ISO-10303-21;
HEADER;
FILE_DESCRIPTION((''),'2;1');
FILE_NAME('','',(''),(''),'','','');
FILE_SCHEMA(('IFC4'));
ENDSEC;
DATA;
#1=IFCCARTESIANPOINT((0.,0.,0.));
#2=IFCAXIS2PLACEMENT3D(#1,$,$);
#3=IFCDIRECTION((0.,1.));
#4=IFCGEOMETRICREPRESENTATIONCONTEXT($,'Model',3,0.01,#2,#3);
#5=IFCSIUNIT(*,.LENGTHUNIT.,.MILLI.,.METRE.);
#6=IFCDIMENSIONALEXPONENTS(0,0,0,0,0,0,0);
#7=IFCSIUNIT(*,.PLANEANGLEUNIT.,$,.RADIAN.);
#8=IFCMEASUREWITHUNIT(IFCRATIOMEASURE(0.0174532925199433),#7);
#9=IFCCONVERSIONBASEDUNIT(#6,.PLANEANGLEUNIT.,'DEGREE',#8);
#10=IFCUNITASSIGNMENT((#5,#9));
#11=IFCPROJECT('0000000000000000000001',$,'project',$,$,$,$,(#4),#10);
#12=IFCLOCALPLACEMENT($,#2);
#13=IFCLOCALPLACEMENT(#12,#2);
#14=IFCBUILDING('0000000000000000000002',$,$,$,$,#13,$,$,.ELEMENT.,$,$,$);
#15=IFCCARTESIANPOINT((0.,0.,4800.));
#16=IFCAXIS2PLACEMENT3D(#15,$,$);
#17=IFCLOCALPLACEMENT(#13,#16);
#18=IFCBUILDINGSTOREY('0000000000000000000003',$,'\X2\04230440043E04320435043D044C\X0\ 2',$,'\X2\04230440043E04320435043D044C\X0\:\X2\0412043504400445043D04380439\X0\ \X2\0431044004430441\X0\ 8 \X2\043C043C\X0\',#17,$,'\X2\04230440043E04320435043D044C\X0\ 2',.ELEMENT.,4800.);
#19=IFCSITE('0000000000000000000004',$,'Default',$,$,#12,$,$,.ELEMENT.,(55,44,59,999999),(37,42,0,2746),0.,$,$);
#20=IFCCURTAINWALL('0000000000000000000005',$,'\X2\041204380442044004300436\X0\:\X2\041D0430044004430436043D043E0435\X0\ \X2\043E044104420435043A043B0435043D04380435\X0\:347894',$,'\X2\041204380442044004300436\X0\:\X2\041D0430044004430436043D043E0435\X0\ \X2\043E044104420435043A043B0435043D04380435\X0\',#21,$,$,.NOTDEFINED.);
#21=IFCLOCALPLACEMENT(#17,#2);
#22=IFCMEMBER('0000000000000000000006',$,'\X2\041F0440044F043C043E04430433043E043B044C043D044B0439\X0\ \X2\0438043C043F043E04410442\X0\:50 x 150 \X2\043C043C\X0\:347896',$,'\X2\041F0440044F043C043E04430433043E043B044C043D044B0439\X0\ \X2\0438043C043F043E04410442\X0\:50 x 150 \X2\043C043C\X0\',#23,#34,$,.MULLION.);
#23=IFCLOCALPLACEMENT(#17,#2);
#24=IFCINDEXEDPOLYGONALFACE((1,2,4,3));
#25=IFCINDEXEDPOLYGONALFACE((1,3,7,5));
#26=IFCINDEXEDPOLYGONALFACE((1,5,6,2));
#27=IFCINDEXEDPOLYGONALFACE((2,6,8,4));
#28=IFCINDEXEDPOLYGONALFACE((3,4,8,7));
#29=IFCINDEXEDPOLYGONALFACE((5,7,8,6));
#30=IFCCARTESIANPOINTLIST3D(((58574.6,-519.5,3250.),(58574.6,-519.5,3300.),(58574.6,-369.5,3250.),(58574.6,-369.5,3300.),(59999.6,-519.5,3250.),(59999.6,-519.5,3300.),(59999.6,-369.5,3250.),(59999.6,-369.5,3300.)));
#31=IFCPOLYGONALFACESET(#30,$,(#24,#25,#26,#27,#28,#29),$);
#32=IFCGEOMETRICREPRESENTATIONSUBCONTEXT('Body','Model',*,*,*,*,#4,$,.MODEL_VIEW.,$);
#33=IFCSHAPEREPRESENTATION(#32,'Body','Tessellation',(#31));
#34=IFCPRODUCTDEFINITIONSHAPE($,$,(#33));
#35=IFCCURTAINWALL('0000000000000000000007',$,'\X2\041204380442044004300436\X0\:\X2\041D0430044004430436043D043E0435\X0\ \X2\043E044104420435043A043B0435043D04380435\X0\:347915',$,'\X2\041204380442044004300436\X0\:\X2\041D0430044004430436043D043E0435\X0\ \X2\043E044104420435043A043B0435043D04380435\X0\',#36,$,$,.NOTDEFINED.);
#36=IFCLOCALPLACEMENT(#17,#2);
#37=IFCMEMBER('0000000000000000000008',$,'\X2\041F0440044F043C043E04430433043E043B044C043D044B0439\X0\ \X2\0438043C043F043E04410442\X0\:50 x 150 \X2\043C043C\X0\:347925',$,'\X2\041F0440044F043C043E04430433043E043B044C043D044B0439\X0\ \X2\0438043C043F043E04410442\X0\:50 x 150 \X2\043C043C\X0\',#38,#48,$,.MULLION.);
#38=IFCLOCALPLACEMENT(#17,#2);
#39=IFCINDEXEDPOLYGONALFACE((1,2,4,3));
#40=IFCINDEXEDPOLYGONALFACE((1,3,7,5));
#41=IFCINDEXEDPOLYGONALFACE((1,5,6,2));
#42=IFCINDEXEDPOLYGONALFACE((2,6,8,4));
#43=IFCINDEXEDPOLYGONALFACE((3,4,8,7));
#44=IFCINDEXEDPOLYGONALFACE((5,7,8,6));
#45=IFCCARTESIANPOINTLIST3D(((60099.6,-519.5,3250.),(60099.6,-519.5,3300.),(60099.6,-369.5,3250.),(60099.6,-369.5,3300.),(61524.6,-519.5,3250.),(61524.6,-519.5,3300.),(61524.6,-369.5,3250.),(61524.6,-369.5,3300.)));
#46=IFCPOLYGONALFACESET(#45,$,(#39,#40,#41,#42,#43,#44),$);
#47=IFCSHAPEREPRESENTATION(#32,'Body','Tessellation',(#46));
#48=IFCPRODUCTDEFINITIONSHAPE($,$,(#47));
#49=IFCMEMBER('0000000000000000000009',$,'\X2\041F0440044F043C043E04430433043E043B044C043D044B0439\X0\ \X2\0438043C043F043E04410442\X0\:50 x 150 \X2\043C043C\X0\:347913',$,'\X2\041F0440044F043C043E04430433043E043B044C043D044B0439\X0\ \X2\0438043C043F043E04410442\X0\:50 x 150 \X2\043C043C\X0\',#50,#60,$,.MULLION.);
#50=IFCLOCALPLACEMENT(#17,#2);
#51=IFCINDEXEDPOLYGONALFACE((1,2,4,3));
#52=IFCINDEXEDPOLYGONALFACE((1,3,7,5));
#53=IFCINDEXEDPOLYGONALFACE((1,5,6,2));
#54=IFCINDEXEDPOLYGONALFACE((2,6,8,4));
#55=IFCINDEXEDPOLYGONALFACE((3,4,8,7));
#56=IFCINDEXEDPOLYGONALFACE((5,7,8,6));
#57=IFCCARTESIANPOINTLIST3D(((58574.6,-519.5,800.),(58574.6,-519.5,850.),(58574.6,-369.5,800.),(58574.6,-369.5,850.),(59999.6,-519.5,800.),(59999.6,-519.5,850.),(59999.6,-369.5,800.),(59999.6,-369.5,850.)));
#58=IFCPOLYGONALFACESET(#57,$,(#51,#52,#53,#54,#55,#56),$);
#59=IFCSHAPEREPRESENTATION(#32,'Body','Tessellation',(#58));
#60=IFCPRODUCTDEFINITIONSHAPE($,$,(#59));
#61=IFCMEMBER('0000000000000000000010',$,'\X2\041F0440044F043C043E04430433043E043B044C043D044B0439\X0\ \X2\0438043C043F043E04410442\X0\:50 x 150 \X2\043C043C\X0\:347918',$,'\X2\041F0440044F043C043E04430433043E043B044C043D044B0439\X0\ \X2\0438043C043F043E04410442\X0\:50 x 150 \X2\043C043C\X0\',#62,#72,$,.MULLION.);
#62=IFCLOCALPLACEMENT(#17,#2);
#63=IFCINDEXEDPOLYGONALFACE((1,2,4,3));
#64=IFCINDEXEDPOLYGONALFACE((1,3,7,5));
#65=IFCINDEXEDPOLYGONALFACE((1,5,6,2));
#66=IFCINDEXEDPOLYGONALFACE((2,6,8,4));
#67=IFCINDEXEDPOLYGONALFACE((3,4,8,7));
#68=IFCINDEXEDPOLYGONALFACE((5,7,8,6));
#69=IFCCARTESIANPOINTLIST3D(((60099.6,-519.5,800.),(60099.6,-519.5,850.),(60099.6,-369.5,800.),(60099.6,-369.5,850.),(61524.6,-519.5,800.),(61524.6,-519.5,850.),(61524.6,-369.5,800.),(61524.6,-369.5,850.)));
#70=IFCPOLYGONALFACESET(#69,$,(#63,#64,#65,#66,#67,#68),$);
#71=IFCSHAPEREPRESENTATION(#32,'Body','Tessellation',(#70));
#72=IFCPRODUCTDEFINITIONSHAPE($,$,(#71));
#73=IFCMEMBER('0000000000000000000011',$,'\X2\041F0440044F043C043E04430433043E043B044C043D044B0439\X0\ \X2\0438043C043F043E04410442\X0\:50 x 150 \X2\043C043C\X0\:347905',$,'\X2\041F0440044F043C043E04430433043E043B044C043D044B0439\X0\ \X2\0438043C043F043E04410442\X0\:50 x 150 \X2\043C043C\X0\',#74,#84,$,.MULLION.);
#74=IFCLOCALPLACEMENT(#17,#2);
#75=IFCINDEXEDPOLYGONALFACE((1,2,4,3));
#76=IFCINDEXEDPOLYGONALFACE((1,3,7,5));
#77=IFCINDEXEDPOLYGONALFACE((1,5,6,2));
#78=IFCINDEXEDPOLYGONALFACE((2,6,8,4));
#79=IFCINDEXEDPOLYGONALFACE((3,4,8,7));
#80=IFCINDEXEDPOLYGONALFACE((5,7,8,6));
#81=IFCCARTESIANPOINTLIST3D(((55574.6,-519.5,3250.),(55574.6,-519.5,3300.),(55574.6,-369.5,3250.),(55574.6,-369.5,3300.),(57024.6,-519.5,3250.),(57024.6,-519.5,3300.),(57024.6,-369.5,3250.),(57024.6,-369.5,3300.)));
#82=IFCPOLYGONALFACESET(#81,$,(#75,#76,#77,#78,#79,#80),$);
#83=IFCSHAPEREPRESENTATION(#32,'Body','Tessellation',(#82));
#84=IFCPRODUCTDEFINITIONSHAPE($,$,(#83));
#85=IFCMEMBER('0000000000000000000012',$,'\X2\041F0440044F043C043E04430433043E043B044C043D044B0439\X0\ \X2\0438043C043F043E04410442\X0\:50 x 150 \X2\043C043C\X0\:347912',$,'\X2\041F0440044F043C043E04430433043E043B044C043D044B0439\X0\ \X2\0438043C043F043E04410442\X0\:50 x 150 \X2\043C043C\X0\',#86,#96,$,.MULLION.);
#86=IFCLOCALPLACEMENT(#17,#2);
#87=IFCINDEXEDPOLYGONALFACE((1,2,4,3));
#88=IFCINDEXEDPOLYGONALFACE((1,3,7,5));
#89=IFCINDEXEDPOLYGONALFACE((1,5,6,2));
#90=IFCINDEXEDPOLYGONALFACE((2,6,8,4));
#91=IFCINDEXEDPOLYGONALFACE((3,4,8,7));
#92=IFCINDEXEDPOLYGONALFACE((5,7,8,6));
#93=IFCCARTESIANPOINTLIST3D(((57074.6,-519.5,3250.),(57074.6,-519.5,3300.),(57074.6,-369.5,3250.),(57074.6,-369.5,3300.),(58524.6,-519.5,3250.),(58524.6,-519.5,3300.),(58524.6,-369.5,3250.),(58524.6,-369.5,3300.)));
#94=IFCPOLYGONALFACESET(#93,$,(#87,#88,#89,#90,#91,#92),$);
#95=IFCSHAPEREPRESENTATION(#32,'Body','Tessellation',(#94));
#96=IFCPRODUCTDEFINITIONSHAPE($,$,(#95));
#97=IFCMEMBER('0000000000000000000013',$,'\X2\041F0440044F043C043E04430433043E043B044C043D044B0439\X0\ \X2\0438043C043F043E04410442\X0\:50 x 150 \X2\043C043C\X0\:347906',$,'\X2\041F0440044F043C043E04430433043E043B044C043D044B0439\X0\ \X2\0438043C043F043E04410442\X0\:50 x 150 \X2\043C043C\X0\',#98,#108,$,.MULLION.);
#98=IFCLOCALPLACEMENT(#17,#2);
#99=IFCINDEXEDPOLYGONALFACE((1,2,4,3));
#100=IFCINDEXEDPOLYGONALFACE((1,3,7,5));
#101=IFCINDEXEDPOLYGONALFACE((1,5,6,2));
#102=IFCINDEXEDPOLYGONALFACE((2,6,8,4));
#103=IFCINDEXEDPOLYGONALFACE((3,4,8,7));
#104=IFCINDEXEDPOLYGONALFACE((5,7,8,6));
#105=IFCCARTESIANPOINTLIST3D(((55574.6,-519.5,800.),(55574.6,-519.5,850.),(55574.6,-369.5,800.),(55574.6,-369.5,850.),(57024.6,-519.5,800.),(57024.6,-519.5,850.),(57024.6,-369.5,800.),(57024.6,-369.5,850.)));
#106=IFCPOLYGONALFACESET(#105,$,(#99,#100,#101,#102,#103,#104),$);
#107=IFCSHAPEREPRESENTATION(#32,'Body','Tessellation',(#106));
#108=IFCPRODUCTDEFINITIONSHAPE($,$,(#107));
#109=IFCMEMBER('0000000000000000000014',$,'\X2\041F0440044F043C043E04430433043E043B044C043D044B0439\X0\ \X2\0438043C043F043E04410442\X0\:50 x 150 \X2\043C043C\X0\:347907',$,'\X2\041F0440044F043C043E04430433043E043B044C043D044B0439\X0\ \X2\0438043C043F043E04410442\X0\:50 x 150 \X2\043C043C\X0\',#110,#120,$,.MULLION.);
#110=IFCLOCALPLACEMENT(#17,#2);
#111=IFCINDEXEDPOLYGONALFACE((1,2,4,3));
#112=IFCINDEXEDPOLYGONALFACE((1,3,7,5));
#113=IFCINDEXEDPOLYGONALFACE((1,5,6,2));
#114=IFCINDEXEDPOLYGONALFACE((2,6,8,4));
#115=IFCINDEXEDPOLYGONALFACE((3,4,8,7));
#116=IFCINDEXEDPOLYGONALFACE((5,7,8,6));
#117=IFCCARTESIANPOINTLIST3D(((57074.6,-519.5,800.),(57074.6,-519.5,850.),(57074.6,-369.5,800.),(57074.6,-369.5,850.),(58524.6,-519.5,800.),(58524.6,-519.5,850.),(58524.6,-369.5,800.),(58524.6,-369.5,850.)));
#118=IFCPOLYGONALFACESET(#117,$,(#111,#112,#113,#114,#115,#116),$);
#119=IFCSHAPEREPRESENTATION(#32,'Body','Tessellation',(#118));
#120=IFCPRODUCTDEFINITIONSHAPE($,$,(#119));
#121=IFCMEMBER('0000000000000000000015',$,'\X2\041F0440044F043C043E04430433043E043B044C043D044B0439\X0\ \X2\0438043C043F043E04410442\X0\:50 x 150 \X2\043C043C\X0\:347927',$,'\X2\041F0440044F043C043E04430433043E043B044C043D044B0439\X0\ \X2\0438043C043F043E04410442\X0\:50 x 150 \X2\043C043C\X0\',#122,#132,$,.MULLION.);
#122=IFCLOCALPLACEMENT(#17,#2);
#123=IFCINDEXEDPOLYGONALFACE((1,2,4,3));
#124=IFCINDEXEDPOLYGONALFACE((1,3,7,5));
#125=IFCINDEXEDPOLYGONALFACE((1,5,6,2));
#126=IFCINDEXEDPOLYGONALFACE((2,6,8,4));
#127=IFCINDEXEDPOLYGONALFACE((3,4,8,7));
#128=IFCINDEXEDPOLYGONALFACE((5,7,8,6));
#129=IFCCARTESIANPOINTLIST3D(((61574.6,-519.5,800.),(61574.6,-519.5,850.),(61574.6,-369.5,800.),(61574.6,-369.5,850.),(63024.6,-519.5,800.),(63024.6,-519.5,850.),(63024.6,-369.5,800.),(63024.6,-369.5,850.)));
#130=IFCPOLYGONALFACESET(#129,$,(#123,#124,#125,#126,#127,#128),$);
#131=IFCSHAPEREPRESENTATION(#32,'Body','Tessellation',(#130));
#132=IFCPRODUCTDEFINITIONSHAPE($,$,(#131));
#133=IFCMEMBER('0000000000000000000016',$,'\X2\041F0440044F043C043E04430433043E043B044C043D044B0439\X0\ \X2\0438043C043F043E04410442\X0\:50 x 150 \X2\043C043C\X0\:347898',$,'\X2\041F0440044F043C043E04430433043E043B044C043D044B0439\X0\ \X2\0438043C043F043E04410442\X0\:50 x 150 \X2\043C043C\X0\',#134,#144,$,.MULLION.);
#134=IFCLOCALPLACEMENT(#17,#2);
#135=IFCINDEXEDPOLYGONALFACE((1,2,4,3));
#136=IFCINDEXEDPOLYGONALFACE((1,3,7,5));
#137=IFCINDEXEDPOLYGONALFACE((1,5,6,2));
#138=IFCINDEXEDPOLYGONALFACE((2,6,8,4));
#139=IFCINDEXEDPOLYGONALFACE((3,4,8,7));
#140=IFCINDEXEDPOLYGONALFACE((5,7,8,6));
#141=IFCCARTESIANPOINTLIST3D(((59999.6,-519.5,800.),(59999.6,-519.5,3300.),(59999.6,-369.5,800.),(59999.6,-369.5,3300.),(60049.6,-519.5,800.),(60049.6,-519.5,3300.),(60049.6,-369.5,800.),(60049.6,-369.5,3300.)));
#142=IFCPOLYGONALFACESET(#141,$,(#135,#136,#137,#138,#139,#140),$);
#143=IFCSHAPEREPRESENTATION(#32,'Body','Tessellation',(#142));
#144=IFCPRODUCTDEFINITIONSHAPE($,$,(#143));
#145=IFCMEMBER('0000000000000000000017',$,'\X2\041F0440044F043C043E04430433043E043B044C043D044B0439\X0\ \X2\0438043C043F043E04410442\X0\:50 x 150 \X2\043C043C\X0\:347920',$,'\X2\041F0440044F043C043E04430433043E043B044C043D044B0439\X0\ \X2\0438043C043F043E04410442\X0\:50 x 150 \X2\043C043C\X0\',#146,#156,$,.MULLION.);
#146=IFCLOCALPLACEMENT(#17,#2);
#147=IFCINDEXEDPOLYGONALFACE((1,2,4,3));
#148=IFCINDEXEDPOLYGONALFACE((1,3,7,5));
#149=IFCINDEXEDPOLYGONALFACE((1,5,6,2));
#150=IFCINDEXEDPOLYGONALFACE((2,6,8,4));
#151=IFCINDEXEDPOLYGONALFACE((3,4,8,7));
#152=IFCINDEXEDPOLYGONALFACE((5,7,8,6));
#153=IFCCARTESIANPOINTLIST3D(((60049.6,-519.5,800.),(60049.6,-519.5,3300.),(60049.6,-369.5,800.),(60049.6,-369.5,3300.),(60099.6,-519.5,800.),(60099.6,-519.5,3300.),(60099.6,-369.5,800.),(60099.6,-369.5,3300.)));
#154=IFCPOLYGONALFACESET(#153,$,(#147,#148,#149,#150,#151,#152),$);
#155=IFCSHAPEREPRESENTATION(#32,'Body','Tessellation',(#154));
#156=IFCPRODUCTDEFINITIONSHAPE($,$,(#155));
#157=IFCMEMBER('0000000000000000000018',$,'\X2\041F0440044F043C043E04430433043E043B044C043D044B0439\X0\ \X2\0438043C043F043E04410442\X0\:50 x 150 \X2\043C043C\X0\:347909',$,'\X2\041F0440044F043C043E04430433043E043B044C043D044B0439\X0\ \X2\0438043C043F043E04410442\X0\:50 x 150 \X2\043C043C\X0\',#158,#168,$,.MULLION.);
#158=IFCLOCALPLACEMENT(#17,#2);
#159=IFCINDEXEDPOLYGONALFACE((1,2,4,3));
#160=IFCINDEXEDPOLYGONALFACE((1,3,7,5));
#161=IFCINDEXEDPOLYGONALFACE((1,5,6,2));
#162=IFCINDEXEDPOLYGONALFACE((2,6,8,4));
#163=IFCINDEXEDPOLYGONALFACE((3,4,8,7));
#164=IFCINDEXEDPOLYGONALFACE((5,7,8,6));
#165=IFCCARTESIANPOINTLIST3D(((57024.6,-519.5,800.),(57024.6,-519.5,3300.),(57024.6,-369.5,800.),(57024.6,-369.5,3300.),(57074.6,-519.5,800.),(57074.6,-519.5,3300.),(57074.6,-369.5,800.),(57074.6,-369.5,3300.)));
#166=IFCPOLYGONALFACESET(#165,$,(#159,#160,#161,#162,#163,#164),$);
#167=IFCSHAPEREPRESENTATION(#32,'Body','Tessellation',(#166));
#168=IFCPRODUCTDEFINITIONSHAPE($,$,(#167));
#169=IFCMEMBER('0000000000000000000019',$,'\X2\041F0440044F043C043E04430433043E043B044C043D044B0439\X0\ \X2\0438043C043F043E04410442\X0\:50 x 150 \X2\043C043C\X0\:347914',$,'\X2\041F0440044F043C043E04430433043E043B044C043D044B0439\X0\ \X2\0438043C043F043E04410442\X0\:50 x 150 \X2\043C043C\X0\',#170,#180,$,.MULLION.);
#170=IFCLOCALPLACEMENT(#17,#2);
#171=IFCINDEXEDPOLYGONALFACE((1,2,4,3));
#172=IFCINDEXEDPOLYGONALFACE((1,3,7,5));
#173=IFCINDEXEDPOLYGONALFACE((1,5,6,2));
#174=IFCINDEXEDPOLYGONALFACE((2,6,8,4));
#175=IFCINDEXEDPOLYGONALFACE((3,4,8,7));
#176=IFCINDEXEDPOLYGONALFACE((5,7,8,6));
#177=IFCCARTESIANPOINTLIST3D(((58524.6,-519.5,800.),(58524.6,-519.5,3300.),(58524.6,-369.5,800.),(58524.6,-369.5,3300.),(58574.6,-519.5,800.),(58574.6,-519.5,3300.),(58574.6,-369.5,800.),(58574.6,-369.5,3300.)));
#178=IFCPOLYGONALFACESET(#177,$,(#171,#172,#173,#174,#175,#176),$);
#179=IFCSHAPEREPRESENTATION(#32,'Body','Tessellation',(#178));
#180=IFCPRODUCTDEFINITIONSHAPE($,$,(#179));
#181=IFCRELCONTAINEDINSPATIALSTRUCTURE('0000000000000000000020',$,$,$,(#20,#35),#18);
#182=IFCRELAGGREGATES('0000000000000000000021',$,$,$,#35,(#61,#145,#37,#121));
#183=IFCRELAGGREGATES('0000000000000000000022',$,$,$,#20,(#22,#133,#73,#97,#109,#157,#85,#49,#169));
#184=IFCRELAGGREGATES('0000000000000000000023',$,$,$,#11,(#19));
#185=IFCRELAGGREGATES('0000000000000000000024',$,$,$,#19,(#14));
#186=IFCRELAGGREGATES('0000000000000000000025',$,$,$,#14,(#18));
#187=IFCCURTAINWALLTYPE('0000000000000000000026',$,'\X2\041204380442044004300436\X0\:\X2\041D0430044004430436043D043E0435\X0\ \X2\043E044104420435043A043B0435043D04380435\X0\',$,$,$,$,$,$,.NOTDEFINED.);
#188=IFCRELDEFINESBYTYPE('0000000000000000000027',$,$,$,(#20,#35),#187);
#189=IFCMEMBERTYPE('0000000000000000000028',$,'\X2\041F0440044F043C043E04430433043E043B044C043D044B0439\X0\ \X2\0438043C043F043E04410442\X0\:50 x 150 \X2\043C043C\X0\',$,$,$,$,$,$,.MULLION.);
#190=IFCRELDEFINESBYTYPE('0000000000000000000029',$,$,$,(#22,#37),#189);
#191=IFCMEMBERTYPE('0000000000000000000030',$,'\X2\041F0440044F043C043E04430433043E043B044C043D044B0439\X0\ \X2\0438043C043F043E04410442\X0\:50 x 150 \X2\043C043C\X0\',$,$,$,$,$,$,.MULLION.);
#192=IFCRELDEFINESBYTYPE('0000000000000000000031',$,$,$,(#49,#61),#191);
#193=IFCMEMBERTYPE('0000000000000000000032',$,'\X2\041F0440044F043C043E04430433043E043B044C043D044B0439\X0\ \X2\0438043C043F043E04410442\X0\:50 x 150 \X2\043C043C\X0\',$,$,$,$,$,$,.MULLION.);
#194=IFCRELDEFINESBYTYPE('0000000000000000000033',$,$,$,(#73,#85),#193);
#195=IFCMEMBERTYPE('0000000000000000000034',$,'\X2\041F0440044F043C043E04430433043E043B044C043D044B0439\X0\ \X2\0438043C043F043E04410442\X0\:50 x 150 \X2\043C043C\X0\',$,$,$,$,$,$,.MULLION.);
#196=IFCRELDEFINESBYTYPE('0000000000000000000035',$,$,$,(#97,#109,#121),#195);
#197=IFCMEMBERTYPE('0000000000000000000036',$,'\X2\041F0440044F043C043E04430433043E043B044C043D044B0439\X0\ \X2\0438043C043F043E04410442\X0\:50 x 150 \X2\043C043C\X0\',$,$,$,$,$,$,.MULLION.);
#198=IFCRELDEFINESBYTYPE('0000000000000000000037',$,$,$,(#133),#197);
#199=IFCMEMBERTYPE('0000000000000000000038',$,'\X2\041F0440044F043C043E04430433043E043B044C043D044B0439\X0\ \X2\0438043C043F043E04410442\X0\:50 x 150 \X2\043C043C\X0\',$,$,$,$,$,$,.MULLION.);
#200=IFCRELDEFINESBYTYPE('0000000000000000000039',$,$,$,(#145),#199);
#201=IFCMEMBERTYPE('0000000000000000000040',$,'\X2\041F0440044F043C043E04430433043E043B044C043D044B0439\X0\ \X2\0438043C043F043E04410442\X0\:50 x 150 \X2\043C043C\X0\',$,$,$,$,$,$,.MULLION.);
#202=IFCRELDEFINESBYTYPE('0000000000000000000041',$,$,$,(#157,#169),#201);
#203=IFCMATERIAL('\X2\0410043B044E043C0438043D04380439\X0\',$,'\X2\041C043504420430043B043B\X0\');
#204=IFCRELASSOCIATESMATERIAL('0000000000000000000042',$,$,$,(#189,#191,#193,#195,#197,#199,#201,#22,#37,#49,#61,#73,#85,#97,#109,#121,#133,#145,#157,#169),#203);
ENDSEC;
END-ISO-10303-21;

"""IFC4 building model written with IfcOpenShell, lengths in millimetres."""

from ifc_helpers import new_model, entity, si_unit, converted_unit, direction, frame, origin, origin_2d_with_axis, place, context, subcontext, project, spatial, rectangle, extrude, source, transform, mapped, material, material_profile, profile_set, profile_usage, type_object, type_shapes, element, aggregate, save


model = new_model("IFC4")

# Units and contexts
model_context = context("Model", 3, precision=0.01, world=origin(), true_north=direction((0.0, 1.0)))
body_context = subcontext(model_context, "Body", "Model", "MODEL_VIEW")
ifc_project = project(units=[si_unit("LENGTHUNIT", "METRE", prefix="MILLI"), converted_unit("PLANEANGLEUNIT", "DEGREE", entity("IfcRatioMeasure", 0.0174532925199433), si_unit("PLANEANGLEUNIT", "RADIAN"), dimensions=[0, 0, 0, 0, 0, 0, 0])], contexts=[model_context])

# Site, building, storey
site_placement = place(None, origin())
site = spatial("IfcSite", under=ifc_project, at=site_placement, Name="Default", CompositionType="ELEMENT", RefLatitude=(55, 44, 59, 999999), RefLongitude=(37, 42, 0, 2746), RefElevation=0.0)
building_placement = place(site_placement, origin())
building = spatial("IfcBuilding", under=site, at=building_placement, CompositionType="ELEMENT")
storey_placement = place(building_placement, frame((0.0, 0.0, 4800.0)))
storey = spatial("IfcBuildingStorey", under=building, at=storey_placement, Name="Уровень 2", ObjectType="Уровень:Верхний брус 8 мм", LongName="Уровень 2", CompositionType="ELEMENT", Elevation=4800.0)

# Curtain walls, members
curtain_wall_type = type_object("IfcCurtainWallType", Name="Витраж:Наружное остекление", PredefinedType="NOTDEFINED")
curtain_wall_1_placement = place(storey_placement, frame((0.0, 0.0, -4800.0)))
curtain_wall_1 = element("IfcCurtainWall", 1, at=curtain_wall_1_placement, inside=storey, type_object=curtain_wall_type, Name="Витраж:Наружное остекление:347894", ObjectType="Витраж:Наружное остекление", PredefinedType="NOTDEFINED")
ifc_material_1 = material(Name="Алюминий", Category="Металл")
ifc_material_profile = material_profile(ifc_material_1, rectangle(XDim=150.0, YDim=50.0, at=origin_2d_with_axis()), Name="50 x 150 мм")
ifc_profile_set = profile_set([ifc_material_profile], Name="50 x 150 мм")
ifc_profile_usage_1 = profile_usage(ifc_profile_set)
member_type_1 = type_object("IfcMemberType", Name="Прямоугольный импост:50 x 150 мм", PredefinedType="MULLION", material=ifc_profile_set)
shared_shape_1 = source(origin(), body_context, "Body", "SweptSolid", [
    extrude(rectangle(XDim=150.0, YDim=50.0, at=origin_2d_with_axis()), frame((-25.0, 0.0, -1425.0), z_axis=(0.0, 0.0, 1.0), x_axis=(0.0, -1.0, 0.0)), (0.0, 0.0, 1.0), 1425.0),
])
type_shapes(member_type_1, [shared_shape_1])
member_1_placement = place(storey_placement, frame((59999.6, -444.5, 3300.0), z_axis=(1.0, 0.0, 0.0), x_axis=(0.0, 0.0, 1.0)))
member_1 = element("IfcMember", 2, at=member_1_placement, type_object=member_type_1, material=ifc_profile_usage_1, Name="Прямоугольный импост:50 x 150 мм:347896", ObjectType="Прямоугольный импост:50 x 150 мм", PredefinedType="MULLION", context=body_context, shape_type="MappedRepresentation", body=[
    mapped(shared_shape_1, transform((0.0, 0.0, 0.0), scale=1.0)),
])
curtain_wall_2_placement = place(storey_placement, frame((0.0, 0.0, -4800.0)))
curtain_wall_2 = element("IfcCurtainWall", 3, at=curtain_wall_2_placement, inside=storey, type_object=curtain_wall_type, Name="Витраж:Наружное остекление:347915", ObjectType="Витраж:Наружное остекление", PredefinedType="NOTDEFINED")
ifc_profile_usage_2 = profile_usage(ifc_profile_set)
member_2_placement = place(storey_placement, frame((61524.6, -444.5, 3300.0), z_axis=(1.0, 0.0, 0.0), x_axis=(0.0, 0.0, 1.0)))
member_2 = element("IfcMember", 4, at=member_2_placement, type_object=member_type_1, material=ifc_profile_usage_2, Name="Прямоугольный импост:50 x 150 мм:347925", ObjectType="Прямоугольный импост:50 x 150 мм", PredefinedType="MULLION", context=body_context, shape_type="MappedRepresentation", body=[
    mapped(shared_shape_1, transform((0.0, 0.0, 0.0), scale=1.0)),
])

# Members
ifc_profile_usage_3 = profile_usage(ifc_profile_set)
member_type_2 = type_object("IfcMemberType", Name="Прямоугольный импост:50 x 150 мм", PredefinedType="MULLION", material=ifc_profile_set)
shared_shape_2 = source(origin(), body_context, "Body", "SweptSolid", [
    extrude(rectangle(XDim=150.0, YDim=50.0, at=origin_2d_with_axis()), frame((-25.0, 0.0, -1425.0), z_axis=(0.0, 0.0, 1.0), x_axis=(0.0, -1.0, 0.0)), (0.0, 0.0, 1.0), 1425.0),
])
type_shapes(member_type_2, [shared_shape_2])
member_3_placement = place(storey_placement, frame((58574.6, -444.5, 800.0), z_axis=(-1.0, 0.0, 0.0), x_axis=(0.0, 0.0, -1.0)))
member_3 = element("IfcMember", 5, at=member_3_placement, type_object=member_type_2, material=ifc_profile_usage_3, Name="Прямоугольный импост:50 x 150 мм:347913", ObjectType="Прямоугольный импост:50 x 150 мм", PredefinedType="MULLION", context=body_context, shape_type="MappedRepresentation", body=[
    mapped(shared_shape_2, transform((0.0, 0.0, 0.0), scale=1.0)),
])
ifc_profile_usage_4 = profile_usage(ifc_profile_set)
member_4_placement = place(storey_placement, frame((60099.6, -444.5, 800.0), z_axis=(-1.0, 0.0, 0.0), x_axis=(0.0, 0.0, -1.0)))
member_4 = element("IfcMember", 6, at=member_4_placement, type_object=member_type_2, material=ifc_profile_usage_4, Name="Прямоугольный импост:50 x 150 мм:347918", ObjectType="Прямоугольный импост:50 x 150 мм", PredefinedType="MULLION", context=body_context, shape_type="MappedRepresentation", body=[
    mapped(shared_shape_2, transform((0.0, 0.0, 0.0), scale=1.0)),
])
ifc_profile_usage_5 = profile_usage(ifc_profile_set)
member_type_3 = type_object("IfcMemberType", Name="Прямоугольный импост:50 x 150 мм", PredefinedType="MULLION", material=ifc_profile_set)
shared_shape_3 = source(origin(), body_context, "Body", "SweptSolid", [
    extrude(rectangle(XDim=150.0, YDim=50.0, at=origin_2d_with_axis()), frame((-25.0, 0.0, -1450.0), z_axis=(0.0, 0.0, 1.0), x_axis=(0.0, -1.0, 0.0)), (0.0, 0.0, 1.0), 1450.0),
])
type_shapes(member_type_3, [shared_shape_3])
member_5_placement = place(storey_placement, frame((57024.6, -444.5, 3300.0), z_axis=(1.0, 0.0, 0.0), x_axis=(0.0, 0.0, 1.0)))
member_5 = element("IfcMember", 7, at=member_5_placement, type_object=member_type_3, material=ifc_profile_usage_5, Name="Прямоугольный импост:50 x 150 мм:347905", ObjectType="Прямоугольный импост:50 x 150 мм", PredefinedType="MULLION", context=body_context, shape_type="MappedRepresentation", body=[
    mapped(shared_shape_3, transform((0.0, 0.0, 0.0), scale=1.0)),
])
ifc_profile_usage_6 = profile_usage(ifc_profile_set)
member_6_placement = place(storey_placement, frame((58524.6, -444.5, 3300.0), z_axis=(1.0, 0.0, 0.0), x_axis=(0.0, 0.0, 1.0)))
member_6 = element("IfcMember", 8, at=member_6_placement, type_object=member_type_3, material=ifc_profile_usage_6, Name="Прямоугольный импост:50 x 150 мм:347912", ObjectType="Прямоугольный импост:50 x 150 мм", PredefinedType="MULLION", context=body_context, shape_type="MappedRepresentation", body=[
    mapped(shared_shape_3, transform((0.0, 0.0, 0.0), scale=1.0)),
])
ifc_profile_usage_7 = profile_usage(ifc_profile_set)
member_type_4 = type_object("IfcMemberType", Name="Прямоугольный импост:50 x 150 мм", PredefinedType="MULLION", material=ifc_profile_set)
shared_shape_4 = source(origin(), body_context, "Body", "SweptSolid", [
    extrude(rectangle(XDim=150.0, YDim=50.0, at=origin_2d_with_axis()), frame((-25.0, 0.0, -1450.0), z_axis=(0.0, 0.0, 1.0), x_axis=(0.0, -1.0, 0.0)), (0.0, 0.0, 1.0), 1450.0),
])
type_shapes(member_type_4, [shared_shape_4])
member_7_placement = place(storey_placement, frame((55574.6, -444.5, 800.0), z_axis=(-1.0, 0.0, 0.0), x_axis=(0.0, 0.0, -1.0)))
member_7 = element("IfcMember", 9, at=member_7_placement, type_object=member_type_4, material=ifc_profile_usage_7, Name="Прямоугольный импост:50 x 150 мм:347906", ObjectType="Прямоугольный импост:50 x 150 мм", PredefinedType="MULLION", context=body_context, shape_type="MappedRepresentation", body=[
    mapped(shared_shape_4, transform((0.0, 0.0, 0.0), scale=1.0)),
])
ifc_profile_usage_8 = profile_usage(ifc_profile_set)
member_8_placement = place(storey_placement, frame((57074.6, -444.5, 800.0), z_axis=(-1.0, 0.0, 0.0), x_axis=(0.0, 0.0, -1.0)))
member_8 = element("IfcMember", 10, at=member_8_placement, type_object=member_type_4, material=ifc_profile_usage_8, Name="Прямоугольный импост:50 x 150 мм:347907", ObjectType="Прямоугольный импост:50 x 150 мм", PredefinedType="MULLION", context=body_context, shape_type="MappedRepresentation", body=[
    mapped(shared_shape_4, transform((0.0, 0.0, 0.0), scale=1.0)),
])
ifc_profile_usage_9 = profile_usage(ifc_profile_set)
member_9_placement = place(storey_placement, frame((61574.6, -444.5, 800.0), z_axis=(-1.0, 0.0, 0.0), x_axis=(0.0, 0.0, -1.0)))
member_9 = element("IfcMember", 11, at=member_9_placement, type_object=member_type_4, material=ifc_profile_usage_9, Name="Прямоугольный импост:50 x 150 мм:347927", ObjectType="Прямоугольный импост:50 x 150 мм", PredefinedType="MULLION", context=body_context, shape_type="MappedRepresentation", body=[
    mapped(shared_shape_4, transform((0.0, 0.0, 0.0), scale=1.0)),
])
ifc_profile_usage_10 = profile_usage(ifc_profile_set)
member_type_5 = type_object("IfcMemberType", Name="Прямоугольный импост:50 x 150 мм", PredefinedType="MULLION", material=ifc_profile_set)
shared_shape_5 = source(origin(), body_context, "Body", "SweptSolid", [
    extrude(rectangle(XDim=150.0, YDim=50.0, at=origin_2d_with_axis()), frame((-25.0, 0.0, -2500.0), z_axis=(0.0, 0.0, 1.0), x_axis=(0.0, -1.0, 0.0)), (0.0, 0.0, 1.0), 2500.0),
])
type_shapes(member_type_5, [shared_shape_5])
member_10_placement = place(storey_placement, frame((60049.6, -444.5, 800.0), z_axis=(0.0, 0.0, -1.0), x_axis=(1.0, 0.0, 0.0)))
member_10 = element("IfcMember", 12, at=member_10_placement, type_object=member_type_5, material=ifc_profile_usage_10, Name="Прямоугольный импост:50 x 150 мм:347898", ObjectType="Прямоугольный импост:50 x 150 мм", PredefinedType="MULLION", context=body_context, shape_type="MappedRepresentation", body=[
    mapped(shared_shape_5, transform((0.0, 0.0, 0.0), scale=1.0)),
])
ifc_profile_usage_11 = profile_usage(ifc_profile_set)
member_type_6 = type_object("IfcMemberType", Name="Прямоугольный импост:50 x 150 мм", PredefinedType="MULLION", material=ifc_profile_set)
shared_shape_6 = source(origin(), body_context, "Body", "SweptSolid", [
    extrude(rectangle(XDim=150.0, YDim=50.0, at=origin_2d_with_axis()), frame((-25.0, 0.0, -2500.0), z_axis=(0.0, 0.0, 1.0), x_axis=(0.0, -1.0, 0.0)), (0.0, 0.0, 1.0), 2500.0),
])
type_shapes(member_type_6, [shared_shape_6])
member_11_placement = place(storey_placement, frame((60049.6, -444.5, 3300.0), z_axis=(0.0, 0.0, 1.0), x_axis=(-1.0, 0.0, 0.0)))
member_11 = element("IfcMember", 13, at=member_11_placement, type_object=member_type_6, material=ifc_profile_usage_11, Name="Прямоугольный импост:50 x 150 мм:347920", ObjectType="Прямоугольный импост:50 x 150 мм", PredefinedType="MULLION", context=body_context, shape_type="MappedRepresentation", body=[
    mapped(shared_shape_6, transform((0.0, 0.0, 0.0), scale=1.0)),
])
ifc_profile_usage_12 = profile_usage(ifc_profile_set)
member_type_7 = type_object("IfcMemberType", Name="Прямоугольный импост:50 x 150 мм", PredefinedType="MULLION", material=ifc_profile_set)
shared_shape_7 = source(origin(), body_context, "Body", "SweptSolid", [
    extrude(rectangle(XDim=150.0, YDim=50.0, at=origin_2d_with_axis()), frame((0.0, 0.0, -2500.0), z_axis=(0.0, 0.0, 1.0), x_axis=(0.0, -1.0, 0.0)), (0.0, 0.0, 1.0), 2500.0),
])
type_shapes(member_type_7, [shared_shape_7])
member_12_placement = place(storey_placement, frame((57049.6, -444.5, 800.0), z_axis=(0.0, 0.0, -1.0), x_axis=(1.0, 0.0, 0.0)))
member_12 = element("IfcMember", 14, at=member_12_placement, type_object=member_type_7, material=ifc_profile_usage_12, Name="Прямоугольный импост:50 x 150 мм:347909", ObjectType="Прямоугольный импост:50 x 150 мм", PredefinedType="MULLION", context=body_context, shape_type="MappedRepresentation", body=[
    mapped(shared_shape_7, transform((0.0, 0.0, 0.0), scale=1.0)),
])
ifc_profile_usage_13 = profile_usage(ifc_profile_set)
member_13_placement = place(storey_placement, frame((58549.6, -444.5, 800.0), z_axis=(0.0, 0.0, -1.0), x_axis=(1.0, 0.0, 0.0)))
member_13 = element("IfcMember", 15, at=member_13_placement, type_object=member_type_7, material=ifc_profile_usage_13, Name="Прямоугольный импост:50 x 150 мм:347914", ObjectType="Прямоугольный импост:50 x 150 мм", PredefinedType="MULLION", context=body_context, shape_type="MappedRepresentation", body=[
    mapped(shared_shape_7, transform((0.0, 0.0, 0.0), scale=1.0)),
])

aggregate(curtain_wall_2, [member_4, member_11, member_2, member_9])
aggregate(curtain_wall_1, [member_1, member_10, member_5, member_7, member_8, member_12, member_6, member_3, member_13])

save(model, "model.ifc")
